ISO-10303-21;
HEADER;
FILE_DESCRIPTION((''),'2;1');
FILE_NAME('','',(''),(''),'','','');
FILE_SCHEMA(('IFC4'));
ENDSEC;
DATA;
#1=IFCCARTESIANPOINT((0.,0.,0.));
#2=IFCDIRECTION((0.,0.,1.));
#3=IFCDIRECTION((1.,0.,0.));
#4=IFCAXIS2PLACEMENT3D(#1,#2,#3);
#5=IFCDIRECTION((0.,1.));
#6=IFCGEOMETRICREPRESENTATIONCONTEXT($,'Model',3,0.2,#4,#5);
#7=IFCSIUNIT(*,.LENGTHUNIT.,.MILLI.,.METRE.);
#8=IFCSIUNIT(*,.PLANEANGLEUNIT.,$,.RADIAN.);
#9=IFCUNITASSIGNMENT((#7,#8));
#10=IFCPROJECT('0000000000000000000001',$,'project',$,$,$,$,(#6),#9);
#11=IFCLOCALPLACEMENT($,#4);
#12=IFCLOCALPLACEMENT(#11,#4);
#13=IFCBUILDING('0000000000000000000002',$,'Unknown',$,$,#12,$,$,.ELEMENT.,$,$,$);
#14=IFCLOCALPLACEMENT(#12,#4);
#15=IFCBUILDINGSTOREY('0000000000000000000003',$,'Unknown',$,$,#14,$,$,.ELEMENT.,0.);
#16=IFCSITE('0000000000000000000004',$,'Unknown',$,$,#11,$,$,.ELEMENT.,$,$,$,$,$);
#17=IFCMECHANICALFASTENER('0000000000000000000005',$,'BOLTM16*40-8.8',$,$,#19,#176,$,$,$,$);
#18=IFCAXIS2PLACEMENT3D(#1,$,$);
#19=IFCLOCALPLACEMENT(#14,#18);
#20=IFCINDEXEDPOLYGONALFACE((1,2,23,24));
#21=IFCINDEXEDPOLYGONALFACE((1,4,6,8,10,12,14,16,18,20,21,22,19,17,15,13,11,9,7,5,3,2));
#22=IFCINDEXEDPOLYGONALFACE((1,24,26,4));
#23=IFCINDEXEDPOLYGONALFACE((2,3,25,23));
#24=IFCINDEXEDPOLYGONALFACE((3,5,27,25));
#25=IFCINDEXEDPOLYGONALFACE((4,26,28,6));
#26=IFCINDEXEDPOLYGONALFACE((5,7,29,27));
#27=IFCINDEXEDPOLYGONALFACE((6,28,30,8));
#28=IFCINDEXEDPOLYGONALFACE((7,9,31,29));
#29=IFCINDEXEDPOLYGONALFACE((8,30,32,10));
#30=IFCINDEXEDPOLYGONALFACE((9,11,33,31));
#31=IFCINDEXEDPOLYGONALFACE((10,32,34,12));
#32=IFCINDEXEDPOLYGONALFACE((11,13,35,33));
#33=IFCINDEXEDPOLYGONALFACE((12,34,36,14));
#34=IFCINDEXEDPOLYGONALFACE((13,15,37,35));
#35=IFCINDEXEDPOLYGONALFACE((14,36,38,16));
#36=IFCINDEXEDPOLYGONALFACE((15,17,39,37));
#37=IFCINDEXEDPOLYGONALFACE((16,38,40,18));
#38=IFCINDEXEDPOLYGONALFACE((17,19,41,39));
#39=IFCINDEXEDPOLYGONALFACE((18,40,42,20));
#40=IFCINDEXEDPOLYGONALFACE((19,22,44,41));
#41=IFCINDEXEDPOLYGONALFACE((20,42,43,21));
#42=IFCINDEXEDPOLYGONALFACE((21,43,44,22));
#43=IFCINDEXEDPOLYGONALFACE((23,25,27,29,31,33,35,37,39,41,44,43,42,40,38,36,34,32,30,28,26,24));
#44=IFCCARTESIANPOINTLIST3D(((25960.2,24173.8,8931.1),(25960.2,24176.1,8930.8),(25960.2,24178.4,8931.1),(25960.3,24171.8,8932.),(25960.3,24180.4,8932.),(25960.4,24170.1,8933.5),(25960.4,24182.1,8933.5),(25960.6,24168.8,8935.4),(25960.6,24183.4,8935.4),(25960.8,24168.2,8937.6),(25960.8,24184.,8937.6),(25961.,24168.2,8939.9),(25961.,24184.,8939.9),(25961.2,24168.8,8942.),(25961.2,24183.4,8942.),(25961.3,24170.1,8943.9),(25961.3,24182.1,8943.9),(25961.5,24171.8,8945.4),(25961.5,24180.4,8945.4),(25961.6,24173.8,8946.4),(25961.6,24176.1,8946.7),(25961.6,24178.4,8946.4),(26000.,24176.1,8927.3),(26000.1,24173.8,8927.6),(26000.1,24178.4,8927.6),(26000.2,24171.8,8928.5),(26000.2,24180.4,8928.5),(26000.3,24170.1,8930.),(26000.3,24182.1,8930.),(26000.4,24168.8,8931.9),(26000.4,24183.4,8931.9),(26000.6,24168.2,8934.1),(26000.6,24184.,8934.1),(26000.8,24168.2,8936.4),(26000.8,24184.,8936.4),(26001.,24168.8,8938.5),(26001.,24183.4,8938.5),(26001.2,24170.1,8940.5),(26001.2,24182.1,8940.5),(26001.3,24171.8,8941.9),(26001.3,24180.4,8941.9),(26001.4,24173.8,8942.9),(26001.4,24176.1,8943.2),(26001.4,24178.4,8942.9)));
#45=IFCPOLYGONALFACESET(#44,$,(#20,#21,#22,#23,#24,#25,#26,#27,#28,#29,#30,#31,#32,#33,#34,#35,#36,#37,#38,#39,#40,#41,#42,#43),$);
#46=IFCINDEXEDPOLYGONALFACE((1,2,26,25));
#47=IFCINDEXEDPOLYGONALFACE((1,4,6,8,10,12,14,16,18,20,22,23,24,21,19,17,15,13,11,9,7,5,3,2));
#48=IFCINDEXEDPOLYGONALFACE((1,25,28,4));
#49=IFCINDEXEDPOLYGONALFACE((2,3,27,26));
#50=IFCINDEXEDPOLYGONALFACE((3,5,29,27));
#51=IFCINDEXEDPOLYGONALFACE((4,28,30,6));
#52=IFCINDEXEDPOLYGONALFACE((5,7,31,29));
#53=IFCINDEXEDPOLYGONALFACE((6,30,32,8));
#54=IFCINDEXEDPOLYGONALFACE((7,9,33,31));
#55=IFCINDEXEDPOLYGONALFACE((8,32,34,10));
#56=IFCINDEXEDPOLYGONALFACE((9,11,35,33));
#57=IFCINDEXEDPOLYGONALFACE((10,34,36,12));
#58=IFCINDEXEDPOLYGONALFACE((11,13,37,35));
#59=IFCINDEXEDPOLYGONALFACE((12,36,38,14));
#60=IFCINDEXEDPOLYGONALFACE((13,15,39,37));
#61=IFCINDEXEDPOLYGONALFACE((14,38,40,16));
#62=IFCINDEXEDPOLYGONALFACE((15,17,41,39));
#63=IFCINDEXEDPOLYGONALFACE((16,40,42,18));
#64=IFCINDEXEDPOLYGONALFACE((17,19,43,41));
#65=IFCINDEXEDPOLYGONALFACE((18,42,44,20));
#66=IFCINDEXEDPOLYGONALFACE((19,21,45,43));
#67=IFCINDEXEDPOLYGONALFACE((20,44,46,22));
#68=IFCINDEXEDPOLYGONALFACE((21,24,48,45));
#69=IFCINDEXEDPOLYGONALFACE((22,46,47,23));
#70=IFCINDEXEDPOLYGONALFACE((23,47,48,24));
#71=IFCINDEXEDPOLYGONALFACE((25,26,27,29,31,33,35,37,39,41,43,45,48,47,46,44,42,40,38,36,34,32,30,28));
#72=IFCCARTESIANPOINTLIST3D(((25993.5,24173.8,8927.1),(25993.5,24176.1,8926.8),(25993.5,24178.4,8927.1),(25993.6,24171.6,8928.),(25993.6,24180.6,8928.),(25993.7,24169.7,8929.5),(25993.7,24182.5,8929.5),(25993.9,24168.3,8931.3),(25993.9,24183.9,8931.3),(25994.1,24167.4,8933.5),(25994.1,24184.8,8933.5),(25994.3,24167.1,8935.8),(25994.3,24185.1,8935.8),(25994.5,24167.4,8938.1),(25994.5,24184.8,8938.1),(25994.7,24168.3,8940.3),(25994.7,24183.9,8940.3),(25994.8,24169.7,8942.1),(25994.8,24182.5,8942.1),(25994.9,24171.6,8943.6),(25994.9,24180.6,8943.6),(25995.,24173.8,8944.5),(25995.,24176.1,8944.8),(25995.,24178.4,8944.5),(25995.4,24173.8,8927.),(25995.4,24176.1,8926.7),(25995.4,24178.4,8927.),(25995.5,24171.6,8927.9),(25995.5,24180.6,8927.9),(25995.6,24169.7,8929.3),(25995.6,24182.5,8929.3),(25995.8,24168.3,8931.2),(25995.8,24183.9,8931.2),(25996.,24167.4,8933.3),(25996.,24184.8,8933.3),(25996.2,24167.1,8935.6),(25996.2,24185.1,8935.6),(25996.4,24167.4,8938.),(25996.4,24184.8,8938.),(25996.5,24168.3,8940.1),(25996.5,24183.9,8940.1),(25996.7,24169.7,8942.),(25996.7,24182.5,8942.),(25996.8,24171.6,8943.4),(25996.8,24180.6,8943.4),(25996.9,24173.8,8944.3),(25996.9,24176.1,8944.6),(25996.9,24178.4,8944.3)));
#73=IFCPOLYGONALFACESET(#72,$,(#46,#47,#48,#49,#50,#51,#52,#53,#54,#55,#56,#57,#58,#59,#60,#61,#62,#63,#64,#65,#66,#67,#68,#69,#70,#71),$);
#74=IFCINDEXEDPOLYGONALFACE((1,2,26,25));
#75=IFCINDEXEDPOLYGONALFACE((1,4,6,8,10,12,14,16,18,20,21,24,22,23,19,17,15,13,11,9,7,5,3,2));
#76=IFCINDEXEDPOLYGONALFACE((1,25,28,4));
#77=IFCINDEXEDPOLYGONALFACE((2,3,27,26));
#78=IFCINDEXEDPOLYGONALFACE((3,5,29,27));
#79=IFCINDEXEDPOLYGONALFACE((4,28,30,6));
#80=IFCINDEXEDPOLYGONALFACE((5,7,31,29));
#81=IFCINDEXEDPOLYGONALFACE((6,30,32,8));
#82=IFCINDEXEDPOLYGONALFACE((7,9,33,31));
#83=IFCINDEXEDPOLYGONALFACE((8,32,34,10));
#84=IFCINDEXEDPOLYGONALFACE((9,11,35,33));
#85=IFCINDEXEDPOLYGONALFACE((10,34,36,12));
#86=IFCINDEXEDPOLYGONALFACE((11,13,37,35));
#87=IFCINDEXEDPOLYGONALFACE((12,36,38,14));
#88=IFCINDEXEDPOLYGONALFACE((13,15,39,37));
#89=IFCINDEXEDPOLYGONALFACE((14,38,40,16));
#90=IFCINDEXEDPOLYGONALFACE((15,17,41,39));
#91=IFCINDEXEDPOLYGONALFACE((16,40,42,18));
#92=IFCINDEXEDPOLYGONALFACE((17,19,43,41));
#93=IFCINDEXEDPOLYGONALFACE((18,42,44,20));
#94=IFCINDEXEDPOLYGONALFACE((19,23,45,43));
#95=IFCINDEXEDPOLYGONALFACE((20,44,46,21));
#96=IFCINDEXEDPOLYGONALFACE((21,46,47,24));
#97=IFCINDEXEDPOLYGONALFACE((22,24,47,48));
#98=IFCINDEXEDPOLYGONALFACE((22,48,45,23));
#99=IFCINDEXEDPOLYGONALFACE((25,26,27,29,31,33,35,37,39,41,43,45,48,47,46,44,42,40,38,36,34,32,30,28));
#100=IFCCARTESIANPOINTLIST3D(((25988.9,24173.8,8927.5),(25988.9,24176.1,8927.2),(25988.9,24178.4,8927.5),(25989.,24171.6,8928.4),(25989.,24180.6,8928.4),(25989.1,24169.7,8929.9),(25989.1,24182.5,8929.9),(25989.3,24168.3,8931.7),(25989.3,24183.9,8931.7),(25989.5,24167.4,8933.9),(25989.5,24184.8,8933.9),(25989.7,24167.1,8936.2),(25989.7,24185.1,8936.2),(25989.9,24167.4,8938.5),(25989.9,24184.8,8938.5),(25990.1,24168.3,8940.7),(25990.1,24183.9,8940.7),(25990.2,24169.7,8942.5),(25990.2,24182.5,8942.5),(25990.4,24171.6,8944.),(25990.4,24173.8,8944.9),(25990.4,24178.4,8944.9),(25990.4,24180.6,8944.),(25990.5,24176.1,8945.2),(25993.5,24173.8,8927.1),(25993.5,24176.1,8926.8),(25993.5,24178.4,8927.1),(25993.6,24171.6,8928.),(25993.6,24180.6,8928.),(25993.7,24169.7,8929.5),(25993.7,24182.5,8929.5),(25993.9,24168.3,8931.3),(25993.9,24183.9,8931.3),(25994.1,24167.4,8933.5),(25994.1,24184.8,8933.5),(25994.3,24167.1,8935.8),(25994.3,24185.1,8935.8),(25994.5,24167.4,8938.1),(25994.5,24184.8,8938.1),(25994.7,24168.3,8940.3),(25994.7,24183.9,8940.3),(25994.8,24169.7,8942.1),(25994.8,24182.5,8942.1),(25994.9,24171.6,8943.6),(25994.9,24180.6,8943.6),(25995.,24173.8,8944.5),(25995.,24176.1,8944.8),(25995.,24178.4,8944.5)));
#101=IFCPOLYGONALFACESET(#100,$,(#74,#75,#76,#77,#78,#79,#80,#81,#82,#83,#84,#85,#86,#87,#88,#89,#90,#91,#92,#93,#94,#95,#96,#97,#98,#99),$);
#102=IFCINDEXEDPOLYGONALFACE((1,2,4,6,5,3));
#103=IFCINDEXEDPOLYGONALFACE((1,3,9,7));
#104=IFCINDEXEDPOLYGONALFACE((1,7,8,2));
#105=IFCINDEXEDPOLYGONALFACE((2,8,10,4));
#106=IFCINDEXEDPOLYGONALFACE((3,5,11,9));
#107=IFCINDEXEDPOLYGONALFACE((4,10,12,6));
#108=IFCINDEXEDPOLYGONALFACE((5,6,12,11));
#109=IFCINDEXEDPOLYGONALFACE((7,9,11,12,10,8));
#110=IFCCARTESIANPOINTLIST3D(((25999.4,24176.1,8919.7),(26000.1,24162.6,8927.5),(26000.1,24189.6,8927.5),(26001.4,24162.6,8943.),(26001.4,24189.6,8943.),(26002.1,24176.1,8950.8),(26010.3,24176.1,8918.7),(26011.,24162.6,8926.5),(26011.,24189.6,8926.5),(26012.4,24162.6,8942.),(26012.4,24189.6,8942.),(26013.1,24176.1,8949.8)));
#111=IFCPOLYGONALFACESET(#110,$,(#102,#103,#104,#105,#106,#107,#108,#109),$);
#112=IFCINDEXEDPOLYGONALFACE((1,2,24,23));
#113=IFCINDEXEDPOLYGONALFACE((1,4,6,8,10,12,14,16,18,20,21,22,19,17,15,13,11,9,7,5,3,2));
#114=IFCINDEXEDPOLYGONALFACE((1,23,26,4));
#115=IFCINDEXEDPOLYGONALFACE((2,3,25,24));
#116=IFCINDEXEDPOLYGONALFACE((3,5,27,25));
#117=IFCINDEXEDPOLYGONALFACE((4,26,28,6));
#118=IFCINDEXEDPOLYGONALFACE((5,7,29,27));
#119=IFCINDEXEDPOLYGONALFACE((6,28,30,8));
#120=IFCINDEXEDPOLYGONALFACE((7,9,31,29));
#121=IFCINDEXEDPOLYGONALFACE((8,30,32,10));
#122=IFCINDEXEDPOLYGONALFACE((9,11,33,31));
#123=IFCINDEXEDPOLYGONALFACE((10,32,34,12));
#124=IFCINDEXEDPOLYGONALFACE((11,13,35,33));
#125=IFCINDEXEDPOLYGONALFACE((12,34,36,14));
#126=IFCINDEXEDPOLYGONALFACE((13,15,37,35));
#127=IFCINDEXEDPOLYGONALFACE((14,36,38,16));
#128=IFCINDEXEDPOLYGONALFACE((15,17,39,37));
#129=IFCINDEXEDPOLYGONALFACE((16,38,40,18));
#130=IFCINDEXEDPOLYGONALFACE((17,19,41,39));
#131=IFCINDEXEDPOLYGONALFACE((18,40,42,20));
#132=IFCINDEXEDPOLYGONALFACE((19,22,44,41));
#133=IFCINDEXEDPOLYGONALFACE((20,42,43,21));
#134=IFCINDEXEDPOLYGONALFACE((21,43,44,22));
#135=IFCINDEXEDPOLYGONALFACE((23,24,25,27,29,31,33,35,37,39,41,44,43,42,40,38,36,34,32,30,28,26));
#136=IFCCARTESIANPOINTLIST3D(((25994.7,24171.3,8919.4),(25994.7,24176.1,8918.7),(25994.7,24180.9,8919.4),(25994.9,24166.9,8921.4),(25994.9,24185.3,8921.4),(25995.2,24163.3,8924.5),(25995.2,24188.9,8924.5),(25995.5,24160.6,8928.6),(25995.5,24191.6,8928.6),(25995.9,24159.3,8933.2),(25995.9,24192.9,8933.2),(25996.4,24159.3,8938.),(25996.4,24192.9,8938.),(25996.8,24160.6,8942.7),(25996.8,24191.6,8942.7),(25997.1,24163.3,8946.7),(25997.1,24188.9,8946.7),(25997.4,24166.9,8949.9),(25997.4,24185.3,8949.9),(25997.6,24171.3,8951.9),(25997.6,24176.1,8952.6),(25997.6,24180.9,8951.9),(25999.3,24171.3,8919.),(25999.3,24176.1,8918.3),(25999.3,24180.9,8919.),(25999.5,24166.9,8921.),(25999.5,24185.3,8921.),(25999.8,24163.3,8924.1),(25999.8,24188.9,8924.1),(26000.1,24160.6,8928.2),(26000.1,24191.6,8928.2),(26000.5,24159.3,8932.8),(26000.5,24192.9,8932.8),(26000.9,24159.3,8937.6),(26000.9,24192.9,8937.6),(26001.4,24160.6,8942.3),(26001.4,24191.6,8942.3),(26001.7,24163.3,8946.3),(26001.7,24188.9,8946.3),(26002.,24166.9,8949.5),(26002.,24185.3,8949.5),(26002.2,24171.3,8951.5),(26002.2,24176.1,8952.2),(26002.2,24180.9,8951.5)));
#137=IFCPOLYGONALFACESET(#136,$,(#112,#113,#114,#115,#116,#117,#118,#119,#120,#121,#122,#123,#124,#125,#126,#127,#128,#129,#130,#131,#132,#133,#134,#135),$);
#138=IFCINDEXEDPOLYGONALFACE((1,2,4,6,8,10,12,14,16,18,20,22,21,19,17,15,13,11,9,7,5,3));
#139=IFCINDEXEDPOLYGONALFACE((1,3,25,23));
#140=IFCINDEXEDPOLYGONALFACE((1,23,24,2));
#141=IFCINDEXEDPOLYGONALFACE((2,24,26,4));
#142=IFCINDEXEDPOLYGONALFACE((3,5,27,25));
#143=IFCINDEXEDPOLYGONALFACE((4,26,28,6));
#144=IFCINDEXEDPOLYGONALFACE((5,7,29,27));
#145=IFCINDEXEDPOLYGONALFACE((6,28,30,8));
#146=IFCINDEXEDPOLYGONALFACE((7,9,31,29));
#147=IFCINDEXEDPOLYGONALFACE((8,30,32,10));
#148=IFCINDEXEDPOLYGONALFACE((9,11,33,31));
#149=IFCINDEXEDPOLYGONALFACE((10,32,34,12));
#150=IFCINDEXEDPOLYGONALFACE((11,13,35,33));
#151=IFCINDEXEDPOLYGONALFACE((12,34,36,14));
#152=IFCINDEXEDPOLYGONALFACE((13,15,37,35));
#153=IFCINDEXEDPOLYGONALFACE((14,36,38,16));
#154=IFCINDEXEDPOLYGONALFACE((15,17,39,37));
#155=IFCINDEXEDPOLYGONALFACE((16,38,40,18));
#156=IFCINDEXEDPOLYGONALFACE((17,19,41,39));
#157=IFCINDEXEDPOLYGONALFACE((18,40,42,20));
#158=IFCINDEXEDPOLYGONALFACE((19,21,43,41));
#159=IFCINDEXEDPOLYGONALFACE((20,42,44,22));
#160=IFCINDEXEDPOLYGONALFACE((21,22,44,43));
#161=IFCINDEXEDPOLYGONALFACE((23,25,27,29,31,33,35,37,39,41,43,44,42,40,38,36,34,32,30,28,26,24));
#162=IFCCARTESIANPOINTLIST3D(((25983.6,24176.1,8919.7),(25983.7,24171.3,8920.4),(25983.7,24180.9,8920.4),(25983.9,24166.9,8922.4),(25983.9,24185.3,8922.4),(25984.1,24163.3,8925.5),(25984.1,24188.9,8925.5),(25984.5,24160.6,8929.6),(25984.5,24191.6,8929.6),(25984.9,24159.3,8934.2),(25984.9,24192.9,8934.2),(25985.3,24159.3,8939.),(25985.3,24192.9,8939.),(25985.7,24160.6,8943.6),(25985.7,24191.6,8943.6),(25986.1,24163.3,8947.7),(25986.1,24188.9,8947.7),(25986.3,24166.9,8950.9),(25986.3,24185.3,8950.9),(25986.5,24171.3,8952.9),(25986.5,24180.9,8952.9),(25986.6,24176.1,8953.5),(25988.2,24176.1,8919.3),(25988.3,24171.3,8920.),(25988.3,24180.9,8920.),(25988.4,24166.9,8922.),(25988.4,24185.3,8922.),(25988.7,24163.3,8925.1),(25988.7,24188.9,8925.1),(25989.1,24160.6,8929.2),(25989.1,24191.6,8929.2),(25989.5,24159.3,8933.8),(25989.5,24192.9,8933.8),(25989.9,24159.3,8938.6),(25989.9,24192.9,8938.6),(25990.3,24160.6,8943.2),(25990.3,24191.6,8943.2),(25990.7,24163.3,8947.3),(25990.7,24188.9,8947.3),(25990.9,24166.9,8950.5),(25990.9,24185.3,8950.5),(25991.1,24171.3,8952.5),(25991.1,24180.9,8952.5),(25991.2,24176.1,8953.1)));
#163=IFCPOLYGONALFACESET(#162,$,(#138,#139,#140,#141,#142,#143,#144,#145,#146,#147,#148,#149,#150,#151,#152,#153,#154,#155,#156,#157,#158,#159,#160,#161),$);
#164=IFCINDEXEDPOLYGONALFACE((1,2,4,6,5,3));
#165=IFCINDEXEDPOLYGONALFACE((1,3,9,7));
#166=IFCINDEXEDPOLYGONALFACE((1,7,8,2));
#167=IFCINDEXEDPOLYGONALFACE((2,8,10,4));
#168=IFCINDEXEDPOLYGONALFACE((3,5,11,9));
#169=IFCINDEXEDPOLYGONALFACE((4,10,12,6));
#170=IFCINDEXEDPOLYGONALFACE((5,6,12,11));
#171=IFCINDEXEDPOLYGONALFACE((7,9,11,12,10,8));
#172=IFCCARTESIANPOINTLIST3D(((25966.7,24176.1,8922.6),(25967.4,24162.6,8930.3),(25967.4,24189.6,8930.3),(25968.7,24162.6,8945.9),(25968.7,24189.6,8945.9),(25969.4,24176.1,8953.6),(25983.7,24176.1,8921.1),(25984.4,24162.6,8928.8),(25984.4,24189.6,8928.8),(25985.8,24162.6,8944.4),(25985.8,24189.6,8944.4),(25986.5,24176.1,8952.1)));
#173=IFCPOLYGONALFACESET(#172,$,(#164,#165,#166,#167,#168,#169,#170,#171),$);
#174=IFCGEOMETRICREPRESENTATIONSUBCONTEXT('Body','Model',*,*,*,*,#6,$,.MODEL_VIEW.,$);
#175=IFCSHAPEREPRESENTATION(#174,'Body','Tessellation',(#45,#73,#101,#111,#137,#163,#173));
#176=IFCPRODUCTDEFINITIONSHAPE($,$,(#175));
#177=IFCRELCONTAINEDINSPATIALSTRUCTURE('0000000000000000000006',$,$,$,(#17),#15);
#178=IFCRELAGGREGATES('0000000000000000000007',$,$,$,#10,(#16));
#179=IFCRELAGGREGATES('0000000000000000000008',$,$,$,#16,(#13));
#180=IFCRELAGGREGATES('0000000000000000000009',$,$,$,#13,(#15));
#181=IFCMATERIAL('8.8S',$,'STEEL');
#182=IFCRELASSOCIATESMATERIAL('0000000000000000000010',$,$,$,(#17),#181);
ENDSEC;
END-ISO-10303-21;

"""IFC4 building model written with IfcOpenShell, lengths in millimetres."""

from ifc_helpers import new_model, si_unit, direction, frame, origin_with_axes, place, context, subcontext, project, spatial, line, arc, indexed_curve, outline, extrude, source, transform, mapped, material, element, save


model = new_model("IFC4")

# Units and contexts
model_context = context("Model", 3, precision=0.2, world=origin_with_axes(), true_north=direction((0.0, 1.0)))
body_context = subcontext(model_context, "Body", "Model", "MODEL_VIEW")
ifc_project = project(units=[si_unit("LENGTHUNIT", "METRE", prefix="MILLI"), si_unit("PLANEANGLEUNIT", "RADIAN")], contexts=[model_context])

# Site, building, storey
site_placement = place(None, origin_with_axes())
site = spatial("IfcSite", under=ifc_project, at=site_placement, Name="Unknown", CompositionType="ELEMENT")
building_placement = place(site_placement, origin_with_axes())
building = spatial("IfcBuilding", under=site, at=building_placement, Name="Unknown", CompositionType="ELEMENT")
storey_placement = place(building_placement, origin_with_axes())
storey = spatial("IfcBuildingStorey", under=building, at=storey_placement, Name="Unknown", CompositionType="ELEMENT", Elevation=0.0)

# Mechanical fastener
ifc_material_1 = material(Name="8.8S", Category="STEEL")
shared_shape_1 = source(origin_with_axes(), body_context, "Body", "SweptSolid", [
    extrude(outline(indexed_curve([(8.0, 0.0), (0.0, 8.0), (-8.0, 0.0), (0.0, -8.0)], segments=[arc(1, 2, 3), arc(3, 4, 1)])), frame((0.0, 0.0, 6.5), z_axis=(0.0, 0.0, -1.0), x_axis=(0.0, 1.0, 0.0)), (0.0, 0.0, 1.0), 40.0),
    extrude(outline(indexed_curve([(0.0, 9.0), (6.4, 6.4), (9.0, 0.0), (6.4, -6.4), (0.0, -9.0), (-0.8, -9.0), (-9.0, 0.0), (-6.4, 6.4)], segments=[arc(1, 2, 3), arc(3, 4, 5), arc(5, 6, 7), arc(7, 8, 1)])), frame((0.0, 0.0, 1.9), z_axis=(0.0, 0.0, -1.0), x_axis=(0.0, 1.0, 0.0)), (0.0, 0.0, 1.0), 1.9),
    extrude(outline(indexed_curve([(0.0, 9.0), (6.4, 6.4), (9.0, 0.0), (6.4, -6.4), (0.0, -9.0), (-0.8, -9.0), (-9.0, 0.0), (-6.4, 6.4)], segments=[arc(1, 2, 3), arc(3, 4, 5), arc(5, 6, 7), arc(7, 8, 1)])), frame((0.0, 0.0, 0.0), z_axis=(0.0, 0.0, -1.0), x_axis=(0.0, 1.0, 0.0)), (0.0, 0.0, 1.0), 4.6),
    extrude(outline(indexed_curve([(15.6, 0.0), (7.8, 13.5), (-7.8, 13.5), (-15.6, 0.0), (-7.8, -13.5), (7.8, -13.5)], segments=[line(1, 2, 3, 4, 5, 6, 1)])), frame((0.0, 0.0, 17.5), z_axis=(0.0, 0.0, -1.0), x_axis=(0.0, 1.0, 0.0)), (0.0, 0.0, 1.0), 11.0),
    extrude(outline(indexed_curve([(17.0, 0.0), (0.0, 17.0), (-17.0, 0.0), (0.0, -17.0)], segments=[arc(1, 2, 3), arc(3, 4, 1)])), frame((0.0, 0.0, 6.5), z_axis=(0.0, 0.0, -1.0), x_axis=(0.0, 1.0, 0.0)), (0.0, 0.0, 1.0), 4.6),
    extrude(outline(indexed_curve([(17.0, 0.0), (0.0, 17.0), (-17.0, 0.0), (0.0, -17.0)], segments=[arc(1, 2, 3), arc(3, 4, 1)])), frame((0.0, 0.0, -4.6), z_axis=(0.0, 0.0, -1.0), x_axis=(0.0, 1.0, 0.0)), (0.0, 0.0, 1.0), 4.6),
    extrude(outline(indexed_curve([(15.6, 0.0), (7.8, 13.5), (-7.8, 13.5), (-15.6, 0.0), (-7.8, -13.5), (7.8, -13.5)], segments=[line(1, 2, 3, 4, 5, 6, 1)])), frame((0.0, 0.0, -9.2), z_axis=(0.0, 0.0, -1.0), x_axis=(0.0, 1.0, 0.0)), (0.0, 0.0, 1.0), 17.1),
])
mechanical_fastener_1_placement = place(storey_placement, frame((25994.3, 24176.1, 8935.8), z_axis=(0.996195, 0.0, -0.087156), x_axis=(0.0, 1.0, 0.0)))
element("IfcMechanicalFastener", 1, at=mechanical_fastener_1_placement, inside=storey, material=ifc_material_1, Name="BOLTM16*40-8.8", context=body_context, shape_type="MappedRepresentation", body=[
    mapped(shared_shape_1, transform((0.0, 0.0, 0.0))),
])

save(model, "model.ifc")
